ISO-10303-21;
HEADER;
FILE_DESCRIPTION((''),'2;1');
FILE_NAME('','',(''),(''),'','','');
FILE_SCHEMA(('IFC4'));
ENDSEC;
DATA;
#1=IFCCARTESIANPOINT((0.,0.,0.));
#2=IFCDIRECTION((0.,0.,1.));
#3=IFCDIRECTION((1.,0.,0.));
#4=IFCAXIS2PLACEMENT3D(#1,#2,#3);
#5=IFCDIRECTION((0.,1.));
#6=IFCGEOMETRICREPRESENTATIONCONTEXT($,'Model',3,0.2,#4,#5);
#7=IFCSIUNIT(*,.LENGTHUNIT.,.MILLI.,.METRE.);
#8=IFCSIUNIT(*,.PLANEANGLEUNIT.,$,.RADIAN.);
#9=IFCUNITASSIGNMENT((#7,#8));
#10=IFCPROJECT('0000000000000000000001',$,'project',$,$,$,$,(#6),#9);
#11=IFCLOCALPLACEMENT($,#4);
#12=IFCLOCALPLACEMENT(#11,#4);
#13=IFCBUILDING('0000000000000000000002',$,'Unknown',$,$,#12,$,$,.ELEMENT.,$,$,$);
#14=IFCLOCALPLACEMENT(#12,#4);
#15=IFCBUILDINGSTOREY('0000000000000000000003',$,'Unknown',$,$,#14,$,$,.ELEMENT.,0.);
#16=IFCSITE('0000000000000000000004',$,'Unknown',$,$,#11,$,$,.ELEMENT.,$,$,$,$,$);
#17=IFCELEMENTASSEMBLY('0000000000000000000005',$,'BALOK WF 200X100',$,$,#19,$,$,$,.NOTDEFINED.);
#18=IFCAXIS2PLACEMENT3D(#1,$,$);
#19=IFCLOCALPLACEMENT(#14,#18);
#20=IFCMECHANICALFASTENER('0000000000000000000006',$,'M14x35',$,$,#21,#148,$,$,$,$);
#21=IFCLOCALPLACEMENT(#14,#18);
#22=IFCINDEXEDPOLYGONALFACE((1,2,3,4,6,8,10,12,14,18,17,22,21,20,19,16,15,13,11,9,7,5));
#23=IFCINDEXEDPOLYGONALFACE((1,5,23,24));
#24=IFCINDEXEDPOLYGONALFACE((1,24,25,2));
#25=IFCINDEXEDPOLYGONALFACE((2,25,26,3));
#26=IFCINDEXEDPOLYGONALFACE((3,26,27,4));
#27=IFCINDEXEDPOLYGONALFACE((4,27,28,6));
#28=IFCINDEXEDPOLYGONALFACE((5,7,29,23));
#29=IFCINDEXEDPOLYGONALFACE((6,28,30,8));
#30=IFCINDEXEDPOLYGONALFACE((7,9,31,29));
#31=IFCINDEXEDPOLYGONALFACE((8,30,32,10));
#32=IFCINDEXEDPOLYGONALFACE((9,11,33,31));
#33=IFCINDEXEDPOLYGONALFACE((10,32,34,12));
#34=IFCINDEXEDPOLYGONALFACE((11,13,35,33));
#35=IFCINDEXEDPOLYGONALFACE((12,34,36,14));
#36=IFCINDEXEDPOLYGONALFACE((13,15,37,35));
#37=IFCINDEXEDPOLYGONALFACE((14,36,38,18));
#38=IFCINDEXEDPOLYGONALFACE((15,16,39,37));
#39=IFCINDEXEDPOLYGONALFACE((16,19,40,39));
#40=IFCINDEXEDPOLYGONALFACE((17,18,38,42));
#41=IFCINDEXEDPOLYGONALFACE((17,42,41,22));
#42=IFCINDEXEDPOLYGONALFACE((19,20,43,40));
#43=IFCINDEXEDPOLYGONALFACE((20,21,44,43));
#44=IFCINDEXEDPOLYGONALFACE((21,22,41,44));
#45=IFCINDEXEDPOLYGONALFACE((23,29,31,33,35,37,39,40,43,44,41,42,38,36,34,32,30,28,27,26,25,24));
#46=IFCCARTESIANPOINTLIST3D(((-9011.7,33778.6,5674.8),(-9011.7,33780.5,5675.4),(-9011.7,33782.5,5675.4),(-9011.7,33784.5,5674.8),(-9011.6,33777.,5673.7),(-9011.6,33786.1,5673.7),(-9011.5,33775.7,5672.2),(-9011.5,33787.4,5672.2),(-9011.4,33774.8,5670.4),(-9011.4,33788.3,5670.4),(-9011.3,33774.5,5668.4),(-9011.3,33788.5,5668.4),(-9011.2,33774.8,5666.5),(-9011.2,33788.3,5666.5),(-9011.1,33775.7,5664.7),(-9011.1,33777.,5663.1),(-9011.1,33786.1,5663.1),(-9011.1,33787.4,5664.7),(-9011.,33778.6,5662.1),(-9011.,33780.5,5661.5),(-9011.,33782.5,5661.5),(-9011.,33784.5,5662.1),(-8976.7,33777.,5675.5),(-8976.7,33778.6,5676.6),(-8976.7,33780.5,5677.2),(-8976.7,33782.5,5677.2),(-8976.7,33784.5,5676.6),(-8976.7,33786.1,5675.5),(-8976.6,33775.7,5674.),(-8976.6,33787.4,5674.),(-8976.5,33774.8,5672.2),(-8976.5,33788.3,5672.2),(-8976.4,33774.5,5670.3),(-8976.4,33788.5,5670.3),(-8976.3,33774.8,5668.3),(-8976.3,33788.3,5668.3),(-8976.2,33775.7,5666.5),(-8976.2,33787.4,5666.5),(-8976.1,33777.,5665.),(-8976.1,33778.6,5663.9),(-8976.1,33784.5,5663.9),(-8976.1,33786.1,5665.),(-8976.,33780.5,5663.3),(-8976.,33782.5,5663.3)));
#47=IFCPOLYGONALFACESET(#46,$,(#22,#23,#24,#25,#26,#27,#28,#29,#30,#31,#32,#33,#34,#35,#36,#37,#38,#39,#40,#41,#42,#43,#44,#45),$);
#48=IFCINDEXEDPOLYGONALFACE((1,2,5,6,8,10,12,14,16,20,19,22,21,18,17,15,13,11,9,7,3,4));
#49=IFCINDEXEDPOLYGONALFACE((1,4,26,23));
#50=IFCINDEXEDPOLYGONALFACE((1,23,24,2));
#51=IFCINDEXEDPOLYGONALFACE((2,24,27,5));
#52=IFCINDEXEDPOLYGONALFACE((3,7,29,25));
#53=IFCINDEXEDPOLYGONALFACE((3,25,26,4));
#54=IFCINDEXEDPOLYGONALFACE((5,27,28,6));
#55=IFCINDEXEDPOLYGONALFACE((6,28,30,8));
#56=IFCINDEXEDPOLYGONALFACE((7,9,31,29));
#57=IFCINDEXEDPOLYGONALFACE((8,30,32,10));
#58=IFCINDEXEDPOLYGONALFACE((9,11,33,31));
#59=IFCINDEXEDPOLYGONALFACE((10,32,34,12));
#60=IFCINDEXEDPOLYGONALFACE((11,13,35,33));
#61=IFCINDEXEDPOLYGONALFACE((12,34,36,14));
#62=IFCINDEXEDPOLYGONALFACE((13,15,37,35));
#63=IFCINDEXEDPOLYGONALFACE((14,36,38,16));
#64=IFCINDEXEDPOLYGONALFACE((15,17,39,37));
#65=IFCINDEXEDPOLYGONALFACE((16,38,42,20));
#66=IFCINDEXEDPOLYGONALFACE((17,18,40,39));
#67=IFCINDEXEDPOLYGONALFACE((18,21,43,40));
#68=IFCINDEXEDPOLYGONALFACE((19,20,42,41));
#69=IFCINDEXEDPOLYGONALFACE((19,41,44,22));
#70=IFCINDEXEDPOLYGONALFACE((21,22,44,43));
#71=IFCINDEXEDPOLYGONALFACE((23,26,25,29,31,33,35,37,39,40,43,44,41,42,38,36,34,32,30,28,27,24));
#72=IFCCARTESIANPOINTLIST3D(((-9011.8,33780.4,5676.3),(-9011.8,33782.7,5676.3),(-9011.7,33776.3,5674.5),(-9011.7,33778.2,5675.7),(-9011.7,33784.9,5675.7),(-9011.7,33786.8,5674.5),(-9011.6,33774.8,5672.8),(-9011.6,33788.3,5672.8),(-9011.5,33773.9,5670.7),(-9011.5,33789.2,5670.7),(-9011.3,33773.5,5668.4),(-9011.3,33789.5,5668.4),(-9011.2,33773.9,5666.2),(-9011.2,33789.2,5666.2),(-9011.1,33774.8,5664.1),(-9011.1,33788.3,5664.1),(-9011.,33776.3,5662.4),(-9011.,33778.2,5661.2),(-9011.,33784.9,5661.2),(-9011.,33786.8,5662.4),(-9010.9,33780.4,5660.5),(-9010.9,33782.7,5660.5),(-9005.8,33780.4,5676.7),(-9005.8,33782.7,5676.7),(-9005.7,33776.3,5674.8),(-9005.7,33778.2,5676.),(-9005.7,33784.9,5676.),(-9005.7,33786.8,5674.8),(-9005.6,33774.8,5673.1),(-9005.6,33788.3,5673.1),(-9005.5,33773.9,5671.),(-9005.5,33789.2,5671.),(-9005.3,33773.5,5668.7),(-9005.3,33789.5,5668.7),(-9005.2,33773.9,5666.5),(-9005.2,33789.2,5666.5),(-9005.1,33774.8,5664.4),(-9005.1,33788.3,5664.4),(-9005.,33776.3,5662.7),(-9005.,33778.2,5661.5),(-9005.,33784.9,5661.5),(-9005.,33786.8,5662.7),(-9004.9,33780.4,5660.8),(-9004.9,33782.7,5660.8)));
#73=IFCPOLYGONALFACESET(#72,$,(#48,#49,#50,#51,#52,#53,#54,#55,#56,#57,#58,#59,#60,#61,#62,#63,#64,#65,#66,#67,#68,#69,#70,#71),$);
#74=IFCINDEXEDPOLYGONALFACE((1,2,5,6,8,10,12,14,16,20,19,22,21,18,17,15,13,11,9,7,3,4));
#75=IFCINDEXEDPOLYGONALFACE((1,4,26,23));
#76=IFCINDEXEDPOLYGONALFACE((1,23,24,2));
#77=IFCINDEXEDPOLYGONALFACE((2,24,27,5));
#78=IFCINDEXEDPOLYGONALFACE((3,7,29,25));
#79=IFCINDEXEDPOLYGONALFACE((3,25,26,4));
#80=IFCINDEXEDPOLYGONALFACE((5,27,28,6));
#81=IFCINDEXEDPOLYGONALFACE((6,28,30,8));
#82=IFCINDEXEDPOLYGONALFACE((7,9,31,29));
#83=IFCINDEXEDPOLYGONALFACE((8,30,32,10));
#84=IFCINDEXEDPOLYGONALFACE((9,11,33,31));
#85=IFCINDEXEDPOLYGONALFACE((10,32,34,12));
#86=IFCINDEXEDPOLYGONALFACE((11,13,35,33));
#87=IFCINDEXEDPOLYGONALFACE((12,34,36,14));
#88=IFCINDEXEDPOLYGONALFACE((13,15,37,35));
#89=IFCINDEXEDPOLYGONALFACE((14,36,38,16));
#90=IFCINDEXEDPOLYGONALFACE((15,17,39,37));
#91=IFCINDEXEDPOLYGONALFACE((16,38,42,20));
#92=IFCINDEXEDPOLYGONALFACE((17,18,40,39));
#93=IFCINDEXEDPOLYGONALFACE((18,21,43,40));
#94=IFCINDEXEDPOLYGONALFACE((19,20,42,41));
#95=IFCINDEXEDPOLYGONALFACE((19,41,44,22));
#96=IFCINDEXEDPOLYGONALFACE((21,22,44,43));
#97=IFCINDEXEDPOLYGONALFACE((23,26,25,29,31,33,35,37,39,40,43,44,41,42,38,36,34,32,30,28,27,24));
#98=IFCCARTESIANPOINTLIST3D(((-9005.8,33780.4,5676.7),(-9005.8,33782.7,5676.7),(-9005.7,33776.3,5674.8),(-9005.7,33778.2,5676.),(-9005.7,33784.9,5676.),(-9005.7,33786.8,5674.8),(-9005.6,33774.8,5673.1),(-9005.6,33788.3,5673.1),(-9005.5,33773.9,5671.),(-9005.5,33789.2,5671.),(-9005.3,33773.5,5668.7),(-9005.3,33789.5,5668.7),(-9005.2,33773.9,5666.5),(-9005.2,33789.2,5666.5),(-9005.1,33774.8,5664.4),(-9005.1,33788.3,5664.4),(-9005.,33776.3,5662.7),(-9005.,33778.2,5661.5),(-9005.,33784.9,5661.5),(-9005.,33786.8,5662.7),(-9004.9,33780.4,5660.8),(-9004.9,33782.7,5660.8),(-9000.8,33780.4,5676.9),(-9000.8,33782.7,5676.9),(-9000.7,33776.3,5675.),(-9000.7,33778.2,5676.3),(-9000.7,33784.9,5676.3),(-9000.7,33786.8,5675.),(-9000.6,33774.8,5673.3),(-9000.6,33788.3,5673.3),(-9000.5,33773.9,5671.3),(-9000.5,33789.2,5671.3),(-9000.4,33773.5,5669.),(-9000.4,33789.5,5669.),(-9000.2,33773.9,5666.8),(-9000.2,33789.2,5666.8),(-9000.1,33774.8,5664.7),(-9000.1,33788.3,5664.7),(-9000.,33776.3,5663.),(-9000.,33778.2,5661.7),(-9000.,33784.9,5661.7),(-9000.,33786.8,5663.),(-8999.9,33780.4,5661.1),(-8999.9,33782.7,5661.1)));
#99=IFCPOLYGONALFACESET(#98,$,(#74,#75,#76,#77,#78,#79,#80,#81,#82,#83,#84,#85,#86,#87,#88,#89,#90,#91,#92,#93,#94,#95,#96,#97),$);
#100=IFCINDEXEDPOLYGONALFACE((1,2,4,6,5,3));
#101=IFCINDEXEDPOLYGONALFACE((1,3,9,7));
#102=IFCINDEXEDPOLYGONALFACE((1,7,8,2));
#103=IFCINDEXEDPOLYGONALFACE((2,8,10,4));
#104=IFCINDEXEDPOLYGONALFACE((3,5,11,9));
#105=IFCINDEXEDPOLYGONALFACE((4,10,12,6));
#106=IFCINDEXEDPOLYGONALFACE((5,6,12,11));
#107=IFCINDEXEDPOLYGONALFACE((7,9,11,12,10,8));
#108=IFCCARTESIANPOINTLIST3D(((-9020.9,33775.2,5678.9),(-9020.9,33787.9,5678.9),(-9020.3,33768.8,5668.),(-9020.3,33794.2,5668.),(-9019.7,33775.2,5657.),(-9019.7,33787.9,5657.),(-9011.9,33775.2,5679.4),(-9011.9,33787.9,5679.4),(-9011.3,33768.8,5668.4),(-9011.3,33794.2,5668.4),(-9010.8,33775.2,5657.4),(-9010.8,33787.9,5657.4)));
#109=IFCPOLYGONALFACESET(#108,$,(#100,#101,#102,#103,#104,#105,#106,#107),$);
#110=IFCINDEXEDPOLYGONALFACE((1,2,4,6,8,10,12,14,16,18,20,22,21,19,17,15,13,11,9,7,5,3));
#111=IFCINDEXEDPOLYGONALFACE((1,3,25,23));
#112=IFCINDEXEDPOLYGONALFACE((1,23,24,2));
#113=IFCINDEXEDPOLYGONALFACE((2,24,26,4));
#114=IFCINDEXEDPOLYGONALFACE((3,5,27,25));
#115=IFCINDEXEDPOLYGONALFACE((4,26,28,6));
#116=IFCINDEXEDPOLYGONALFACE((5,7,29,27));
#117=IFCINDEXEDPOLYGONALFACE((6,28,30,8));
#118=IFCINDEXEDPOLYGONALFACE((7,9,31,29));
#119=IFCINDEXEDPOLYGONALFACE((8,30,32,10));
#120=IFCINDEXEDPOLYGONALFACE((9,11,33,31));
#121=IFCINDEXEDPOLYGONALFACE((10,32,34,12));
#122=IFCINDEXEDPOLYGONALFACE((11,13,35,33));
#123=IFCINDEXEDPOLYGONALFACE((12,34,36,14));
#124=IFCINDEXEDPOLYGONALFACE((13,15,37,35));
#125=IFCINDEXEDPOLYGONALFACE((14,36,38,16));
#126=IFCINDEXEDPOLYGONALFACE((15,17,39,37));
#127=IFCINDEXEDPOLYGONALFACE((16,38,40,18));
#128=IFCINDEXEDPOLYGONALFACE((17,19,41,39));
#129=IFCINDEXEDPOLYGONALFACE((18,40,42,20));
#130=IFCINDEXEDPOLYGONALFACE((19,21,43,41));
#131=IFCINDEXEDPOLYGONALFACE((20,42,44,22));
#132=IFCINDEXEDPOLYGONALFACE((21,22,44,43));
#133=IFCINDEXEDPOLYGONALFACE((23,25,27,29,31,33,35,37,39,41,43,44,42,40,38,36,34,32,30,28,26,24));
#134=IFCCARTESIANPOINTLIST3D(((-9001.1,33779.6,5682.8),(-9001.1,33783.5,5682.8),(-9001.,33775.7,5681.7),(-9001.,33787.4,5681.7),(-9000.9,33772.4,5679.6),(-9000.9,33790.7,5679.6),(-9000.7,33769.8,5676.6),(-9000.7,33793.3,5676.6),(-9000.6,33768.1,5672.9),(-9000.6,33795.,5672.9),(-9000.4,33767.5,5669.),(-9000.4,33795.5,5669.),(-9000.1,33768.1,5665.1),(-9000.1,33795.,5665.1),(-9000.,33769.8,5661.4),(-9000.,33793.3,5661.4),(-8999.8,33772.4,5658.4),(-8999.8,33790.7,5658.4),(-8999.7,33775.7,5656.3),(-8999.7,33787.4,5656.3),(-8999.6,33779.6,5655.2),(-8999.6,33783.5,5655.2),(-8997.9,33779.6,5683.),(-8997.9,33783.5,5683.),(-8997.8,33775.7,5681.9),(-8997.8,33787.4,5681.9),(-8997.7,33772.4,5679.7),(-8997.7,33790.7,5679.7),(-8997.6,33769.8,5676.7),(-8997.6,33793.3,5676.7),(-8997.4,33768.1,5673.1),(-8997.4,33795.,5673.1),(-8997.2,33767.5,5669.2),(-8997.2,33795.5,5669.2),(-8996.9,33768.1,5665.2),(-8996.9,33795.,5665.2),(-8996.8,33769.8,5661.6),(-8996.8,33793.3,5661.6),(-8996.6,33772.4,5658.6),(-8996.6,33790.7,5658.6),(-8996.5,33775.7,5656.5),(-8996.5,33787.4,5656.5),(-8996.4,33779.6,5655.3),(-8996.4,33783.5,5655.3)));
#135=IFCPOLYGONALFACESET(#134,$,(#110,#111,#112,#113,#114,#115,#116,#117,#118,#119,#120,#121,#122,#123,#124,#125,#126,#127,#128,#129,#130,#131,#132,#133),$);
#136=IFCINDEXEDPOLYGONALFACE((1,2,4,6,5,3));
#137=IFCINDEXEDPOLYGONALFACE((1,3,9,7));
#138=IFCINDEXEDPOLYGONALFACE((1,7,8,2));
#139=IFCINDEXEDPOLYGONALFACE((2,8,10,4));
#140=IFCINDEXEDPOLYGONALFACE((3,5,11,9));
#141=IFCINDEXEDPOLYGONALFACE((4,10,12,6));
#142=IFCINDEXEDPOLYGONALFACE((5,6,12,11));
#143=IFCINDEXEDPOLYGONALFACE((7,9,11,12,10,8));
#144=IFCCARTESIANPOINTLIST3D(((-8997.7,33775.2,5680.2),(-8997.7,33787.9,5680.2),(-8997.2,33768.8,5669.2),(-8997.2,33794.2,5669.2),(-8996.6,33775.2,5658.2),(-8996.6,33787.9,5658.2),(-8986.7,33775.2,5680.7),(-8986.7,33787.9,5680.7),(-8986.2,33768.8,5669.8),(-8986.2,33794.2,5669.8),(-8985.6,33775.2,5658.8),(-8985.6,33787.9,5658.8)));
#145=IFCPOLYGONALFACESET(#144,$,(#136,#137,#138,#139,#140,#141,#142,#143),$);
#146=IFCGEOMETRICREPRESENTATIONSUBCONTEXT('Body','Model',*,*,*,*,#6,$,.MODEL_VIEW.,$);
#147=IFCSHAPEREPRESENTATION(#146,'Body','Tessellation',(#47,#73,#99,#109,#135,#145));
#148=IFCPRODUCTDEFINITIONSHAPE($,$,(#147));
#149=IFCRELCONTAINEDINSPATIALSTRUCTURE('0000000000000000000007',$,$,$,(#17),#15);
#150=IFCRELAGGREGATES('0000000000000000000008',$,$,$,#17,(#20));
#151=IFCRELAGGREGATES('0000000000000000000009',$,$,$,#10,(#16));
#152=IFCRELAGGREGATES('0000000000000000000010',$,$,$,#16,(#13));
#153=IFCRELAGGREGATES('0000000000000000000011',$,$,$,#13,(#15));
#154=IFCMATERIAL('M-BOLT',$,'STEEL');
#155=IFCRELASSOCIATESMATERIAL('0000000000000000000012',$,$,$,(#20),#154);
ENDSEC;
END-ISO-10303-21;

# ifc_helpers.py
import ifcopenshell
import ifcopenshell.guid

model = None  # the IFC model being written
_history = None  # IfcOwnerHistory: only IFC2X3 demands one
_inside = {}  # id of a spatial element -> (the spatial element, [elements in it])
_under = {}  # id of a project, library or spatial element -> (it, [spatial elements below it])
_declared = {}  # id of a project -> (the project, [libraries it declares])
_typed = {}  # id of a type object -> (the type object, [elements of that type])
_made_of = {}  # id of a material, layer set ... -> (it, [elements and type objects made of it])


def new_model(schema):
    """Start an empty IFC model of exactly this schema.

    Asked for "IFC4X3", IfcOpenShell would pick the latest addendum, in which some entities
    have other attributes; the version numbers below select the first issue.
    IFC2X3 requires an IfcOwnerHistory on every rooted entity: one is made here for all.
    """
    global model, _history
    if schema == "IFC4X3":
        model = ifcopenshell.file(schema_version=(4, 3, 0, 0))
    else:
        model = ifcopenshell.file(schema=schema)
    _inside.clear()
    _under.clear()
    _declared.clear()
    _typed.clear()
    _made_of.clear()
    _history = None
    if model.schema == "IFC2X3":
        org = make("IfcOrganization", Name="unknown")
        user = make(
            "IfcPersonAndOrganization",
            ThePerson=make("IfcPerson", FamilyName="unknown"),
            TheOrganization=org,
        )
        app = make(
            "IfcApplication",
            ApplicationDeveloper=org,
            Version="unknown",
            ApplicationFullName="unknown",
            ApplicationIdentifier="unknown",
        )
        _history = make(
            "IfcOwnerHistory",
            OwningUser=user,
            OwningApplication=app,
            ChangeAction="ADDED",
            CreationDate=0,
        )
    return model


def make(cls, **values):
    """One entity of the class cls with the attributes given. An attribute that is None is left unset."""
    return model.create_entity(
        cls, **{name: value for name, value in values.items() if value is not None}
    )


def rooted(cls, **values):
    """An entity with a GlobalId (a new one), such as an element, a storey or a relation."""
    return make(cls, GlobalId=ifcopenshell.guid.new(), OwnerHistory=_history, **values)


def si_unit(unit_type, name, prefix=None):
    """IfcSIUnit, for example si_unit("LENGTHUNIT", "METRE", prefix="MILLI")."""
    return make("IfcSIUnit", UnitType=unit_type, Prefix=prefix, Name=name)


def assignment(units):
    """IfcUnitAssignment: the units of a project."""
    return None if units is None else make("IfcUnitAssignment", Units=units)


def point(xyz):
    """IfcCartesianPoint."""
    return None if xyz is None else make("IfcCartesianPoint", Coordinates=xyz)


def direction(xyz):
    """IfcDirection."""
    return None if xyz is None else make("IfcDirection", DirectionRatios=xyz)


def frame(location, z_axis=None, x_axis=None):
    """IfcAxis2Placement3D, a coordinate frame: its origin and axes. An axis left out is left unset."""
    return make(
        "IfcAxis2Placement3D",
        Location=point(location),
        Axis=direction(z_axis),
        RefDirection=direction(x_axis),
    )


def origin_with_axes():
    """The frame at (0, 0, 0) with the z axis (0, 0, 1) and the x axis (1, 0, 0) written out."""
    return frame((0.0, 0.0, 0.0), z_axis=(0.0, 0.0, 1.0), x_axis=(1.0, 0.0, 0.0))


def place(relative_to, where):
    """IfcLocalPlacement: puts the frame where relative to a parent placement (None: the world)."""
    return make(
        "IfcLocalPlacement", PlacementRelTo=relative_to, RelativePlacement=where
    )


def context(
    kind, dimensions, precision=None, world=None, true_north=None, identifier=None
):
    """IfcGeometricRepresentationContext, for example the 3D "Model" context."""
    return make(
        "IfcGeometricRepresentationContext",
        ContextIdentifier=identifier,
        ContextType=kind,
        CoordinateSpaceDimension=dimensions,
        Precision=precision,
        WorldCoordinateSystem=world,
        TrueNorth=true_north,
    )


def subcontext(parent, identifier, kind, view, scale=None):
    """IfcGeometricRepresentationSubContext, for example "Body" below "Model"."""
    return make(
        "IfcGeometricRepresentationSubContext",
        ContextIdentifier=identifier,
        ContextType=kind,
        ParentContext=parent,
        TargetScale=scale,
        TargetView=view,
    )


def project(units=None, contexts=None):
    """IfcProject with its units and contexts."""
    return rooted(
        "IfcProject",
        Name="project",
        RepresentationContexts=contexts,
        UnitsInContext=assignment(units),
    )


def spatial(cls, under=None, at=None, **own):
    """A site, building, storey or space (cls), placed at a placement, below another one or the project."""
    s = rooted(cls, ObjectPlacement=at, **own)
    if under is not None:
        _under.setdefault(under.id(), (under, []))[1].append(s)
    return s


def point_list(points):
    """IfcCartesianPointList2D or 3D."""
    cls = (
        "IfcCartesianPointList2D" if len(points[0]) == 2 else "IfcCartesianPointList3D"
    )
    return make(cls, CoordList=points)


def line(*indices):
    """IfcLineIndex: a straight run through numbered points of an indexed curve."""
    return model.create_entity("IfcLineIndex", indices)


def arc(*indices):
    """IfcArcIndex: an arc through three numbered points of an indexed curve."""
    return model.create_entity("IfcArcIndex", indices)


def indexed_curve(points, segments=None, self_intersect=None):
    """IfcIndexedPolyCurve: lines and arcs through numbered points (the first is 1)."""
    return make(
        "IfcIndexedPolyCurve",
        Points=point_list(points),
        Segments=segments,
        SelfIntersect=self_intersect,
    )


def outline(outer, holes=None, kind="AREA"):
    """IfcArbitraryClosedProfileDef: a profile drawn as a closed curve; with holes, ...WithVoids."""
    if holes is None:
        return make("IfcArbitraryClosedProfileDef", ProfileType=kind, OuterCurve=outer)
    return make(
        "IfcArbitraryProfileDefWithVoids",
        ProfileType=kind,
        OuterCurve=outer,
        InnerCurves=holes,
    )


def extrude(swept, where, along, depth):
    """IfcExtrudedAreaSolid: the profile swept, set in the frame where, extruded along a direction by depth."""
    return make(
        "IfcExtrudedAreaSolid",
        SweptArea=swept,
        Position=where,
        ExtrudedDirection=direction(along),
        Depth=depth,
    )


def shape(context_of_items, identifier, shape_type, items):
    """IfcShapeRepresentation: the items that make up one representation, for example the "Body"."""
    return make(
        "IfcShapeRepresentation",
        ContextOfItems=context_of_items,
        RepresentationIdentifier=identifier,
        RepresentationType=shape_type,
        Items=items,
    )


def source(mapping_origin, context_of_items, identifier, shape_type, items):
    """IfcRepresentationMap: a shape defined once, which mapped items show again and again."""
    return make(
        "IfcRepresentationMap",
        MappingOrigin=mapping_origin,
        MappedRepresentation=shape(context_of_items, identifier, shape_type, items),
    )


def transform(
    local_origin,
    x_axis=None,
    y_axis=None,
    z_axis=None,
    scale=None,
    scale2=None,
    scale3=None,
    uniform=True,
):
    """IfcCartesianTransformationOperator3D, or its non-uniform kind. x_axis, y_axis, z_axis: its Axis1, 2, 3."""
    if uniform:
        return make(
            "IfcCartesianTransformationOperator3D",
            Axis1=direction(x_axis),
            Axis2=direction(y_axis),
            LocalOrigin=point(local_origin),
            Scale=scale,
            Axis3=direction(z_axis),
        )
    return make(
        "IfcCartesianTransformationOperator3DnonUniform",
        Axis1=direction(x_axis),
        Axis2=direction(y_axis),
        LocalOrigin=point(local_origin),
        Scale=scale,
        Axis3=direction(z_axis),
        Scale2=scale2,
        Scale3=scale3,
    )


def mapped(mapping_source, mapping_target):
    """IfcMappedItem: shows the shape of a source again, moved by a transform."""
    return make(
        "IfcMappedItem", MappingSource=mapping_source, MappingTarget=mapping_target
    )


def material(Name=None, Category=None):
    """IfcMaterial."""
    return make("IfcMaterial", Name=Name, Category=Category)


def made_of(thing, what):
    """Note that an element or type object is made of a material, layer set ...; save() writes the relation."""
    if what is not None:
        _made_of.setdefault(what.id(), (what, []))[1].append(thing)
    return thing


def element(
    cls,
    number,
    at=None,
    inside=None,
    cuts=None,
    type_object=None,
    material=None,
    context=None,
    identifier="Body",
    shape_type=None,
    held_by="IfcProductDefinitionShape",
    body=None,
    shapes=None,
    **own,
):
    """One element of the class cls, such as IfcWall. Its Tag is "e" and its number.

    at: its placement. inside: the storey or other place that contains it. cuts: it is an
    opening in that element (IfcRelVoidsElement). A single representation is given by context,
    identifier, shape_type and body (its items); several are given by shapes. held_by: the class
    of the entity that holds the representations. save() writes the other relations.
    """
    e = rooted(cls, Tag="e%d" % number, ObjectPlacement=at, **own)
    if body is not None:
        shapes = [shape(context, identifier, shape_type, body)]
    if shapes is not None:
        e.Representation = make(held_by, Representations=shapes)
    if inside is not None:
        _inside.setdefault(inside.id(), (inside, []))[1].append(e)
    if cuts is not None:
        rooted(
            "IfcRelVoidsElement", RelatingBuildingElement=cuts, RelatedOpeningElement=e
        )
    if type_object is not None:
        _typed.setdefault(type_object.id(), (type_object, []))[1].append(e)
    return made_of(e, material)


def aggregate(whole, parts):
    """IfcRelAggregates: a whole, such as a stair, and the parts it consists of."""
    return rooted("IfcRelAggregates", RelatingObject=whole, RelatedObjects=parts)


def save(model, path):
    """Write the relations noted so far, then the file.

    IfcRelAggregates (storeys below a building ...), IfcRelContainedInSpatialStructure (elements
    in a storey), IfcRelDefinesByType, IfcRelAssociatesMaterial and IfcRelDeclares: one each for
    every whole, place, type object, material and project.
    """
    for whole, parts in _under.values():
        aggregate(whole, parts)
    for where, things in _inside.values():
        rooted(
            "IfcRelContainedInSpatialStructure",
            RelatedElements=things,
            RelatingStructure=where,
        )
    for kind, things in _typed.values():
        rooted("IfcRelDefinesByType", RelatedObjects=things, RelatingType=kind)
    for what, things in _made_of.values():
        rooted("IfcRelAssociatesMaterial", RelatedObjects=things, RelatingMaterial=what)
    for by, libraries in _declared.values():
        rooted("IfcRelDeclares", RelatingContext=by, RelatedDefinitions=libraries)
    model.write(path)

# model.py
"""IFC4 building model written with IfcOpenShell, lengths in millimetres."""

from ifc_helpers import new_model, si_unit, direction, frame, origin_with_axes, place, context, subcontext, project, spatial, line, arc, indexed_curve, outline, extrude, source, transform, mapped, material, element, aggregate, save


model = new_model("IFC4")

# Units and contexts
model_context = context("Model", 3, precision=0.2, world=origin_with_axes(), true_north=direction((0.0, 1.0)))
body_context = subcontext(model_context, "Body", "Model", "MODEL_VIEW")
ifc_project = project(units=[si_unit("LENGTHUNIT", "METRE", prefix="MILLI"), si_unit("PLANEANGLEUNIT", "RADIAN")], contexts=[model_context])

# Site, building, storey
site_placement = place(None, origin_with_axes())
site = spatial("IfcSite", under=ifc_project, at=site_placement, Name="Unknown", CompositionType="ELEMENT")
building_placement = place(site_placement, origin_with_axes())
building = spatial("IfcBuilding", under=site, at=building_placement, Name="Unknown", CompositionType="ELEMENT")
storey_placement = place(building_placement, origin_with_axes())
storey = spatial("IfcBuildingStorey", under=building, at=storey_placement, Name="Unknown", CompositionType="ELEMENT", Elevation=0.0)

# Shared definitions
ifc_material_1 = material(Name="M-BOLT", Category="STEEL")

# Element assembly, mechanical fastener
assembly_1_placement = place(storey_placement, frame((-7044.1, 33866.5, 5721.5), z_axis=(0.0, 1.0, 0.0), x_axis=(-0.99863, 0.0, -0.052336)))
assembly_1 = element("IfcElementAssembly", 1, at=assembly_1_placement, inside=storey, Name="BALOK WF 200X100", PredefinedType="NOTDEFINED")
shared_shape_1 = source(origin_with_axes(), body_context, "Body", "SweptSolid", [
    extrude(outline(indexed_curve([(7.0, 0.0), (0.0, 7.0), (-7.0, 0.0), (0.0, -7.0)], segments=[arc(1, 2, 3), arc(3, 4, 1)])), frame((0.0, 0.0, 0.0), z_axis=(0.0, 0.0, -1.0), x_axis=(0.0, 1.0, 0.0)), (0.0, 0.0, 1.0), 35.0),
    extrude(outline(indexed_curve([(8.0, 0.0), (0.0, 8.0), (-8.0, 0.0), (0.0, -8.0)], segments=[arc(1, 2, 3), arc(3, 4, 1)])), frame((0.0, 0.0, 0.0), z_axis=(0.0, 0.0, -1.0), x_axis=(0.0, 1.0, 0.0)), (0.0, 0.0, 1.0), 6.0),
    extrude(outline(indexed_curve([(8.0, 0.0), (0.0, 8.0), (-8.0, 0.0), (0.0, -8.0)], segments=[arc(1, 2, 3), arc(3, 4, 1)])), frame((0.0, 0.0, -6.0), z_axis=(0.0, 0.0, -1.0), x_axis=(0.0, 1.0, 0.0)), (0.0, 0.0, 1.0), 5.0),
    extrude(outline(indexed_curve([(12.7, 0.0), (6.4, 11.0), (-6.4, 11.0), (-12.7, 0.0), (-6.4, -11.0), (6.4, -11.0)], segments=[line(1, 2, 3, 4, 5, 6, 1)])), frame((0.0, 0.0, 9.0), z_axis=(0.0, 0.0, -1.0), x_axis=(0.0, 1.0, 0.0)), (0.0, 0.0, 1.0), 9.0),
    extrude(outline(indexed_curve([(14.0, 0.0), (0.0, 14.0), (-14.0, 0.0), (0.0, -14.0)], segments=[arc(1, 2, 3), arc(3, 4, 1)])), frame((0.0, 0.0, -11.0), z_axis=(0.0, 0.0, -1.0), x_axis=(0.0, 1.0, 0.0)), (0.0, 0.0, 1.0), 3.2),
    extrude(outline(indexed_curve([(12.7, 0.0), (6.4, 11.0), (-6.4, 11.0), (-12.7, 0.0), (-6.4, -11.0), (6.4, -11.0)], segments=[line(1, 2, 3, 4, 5, 6, 1)])), frame((0.0, 0.0, -14.2), z_axis=(0.0, 0.0, -1.0), x_axis=(0.0, 1.0, 0.0)), (0.0, 0.0, 1.0), 11.0),
])
mechanical_fastener_1_placement = place(assembly_1_placement, frame((1967.3, 50.0, -85.0), z_axis=(1.0, 0.0, -0.000006), x_axis=(0.0, -1.0, 0.0)))
mechanical_fastener_1 = element("IfcMechanicalFastener", 2, at=mechanical_fastener_1_placement, material=ifc_material_1, Name="M14x35", context=body_context, shape_type="MappedRepresentation", body=[
    mapped(shared_shape_1, transform((0.0, 0.0, 0.0))),
])

aggregate(assembly_1, [mechanical_fastener_1])

save(model, "model.ifc")
